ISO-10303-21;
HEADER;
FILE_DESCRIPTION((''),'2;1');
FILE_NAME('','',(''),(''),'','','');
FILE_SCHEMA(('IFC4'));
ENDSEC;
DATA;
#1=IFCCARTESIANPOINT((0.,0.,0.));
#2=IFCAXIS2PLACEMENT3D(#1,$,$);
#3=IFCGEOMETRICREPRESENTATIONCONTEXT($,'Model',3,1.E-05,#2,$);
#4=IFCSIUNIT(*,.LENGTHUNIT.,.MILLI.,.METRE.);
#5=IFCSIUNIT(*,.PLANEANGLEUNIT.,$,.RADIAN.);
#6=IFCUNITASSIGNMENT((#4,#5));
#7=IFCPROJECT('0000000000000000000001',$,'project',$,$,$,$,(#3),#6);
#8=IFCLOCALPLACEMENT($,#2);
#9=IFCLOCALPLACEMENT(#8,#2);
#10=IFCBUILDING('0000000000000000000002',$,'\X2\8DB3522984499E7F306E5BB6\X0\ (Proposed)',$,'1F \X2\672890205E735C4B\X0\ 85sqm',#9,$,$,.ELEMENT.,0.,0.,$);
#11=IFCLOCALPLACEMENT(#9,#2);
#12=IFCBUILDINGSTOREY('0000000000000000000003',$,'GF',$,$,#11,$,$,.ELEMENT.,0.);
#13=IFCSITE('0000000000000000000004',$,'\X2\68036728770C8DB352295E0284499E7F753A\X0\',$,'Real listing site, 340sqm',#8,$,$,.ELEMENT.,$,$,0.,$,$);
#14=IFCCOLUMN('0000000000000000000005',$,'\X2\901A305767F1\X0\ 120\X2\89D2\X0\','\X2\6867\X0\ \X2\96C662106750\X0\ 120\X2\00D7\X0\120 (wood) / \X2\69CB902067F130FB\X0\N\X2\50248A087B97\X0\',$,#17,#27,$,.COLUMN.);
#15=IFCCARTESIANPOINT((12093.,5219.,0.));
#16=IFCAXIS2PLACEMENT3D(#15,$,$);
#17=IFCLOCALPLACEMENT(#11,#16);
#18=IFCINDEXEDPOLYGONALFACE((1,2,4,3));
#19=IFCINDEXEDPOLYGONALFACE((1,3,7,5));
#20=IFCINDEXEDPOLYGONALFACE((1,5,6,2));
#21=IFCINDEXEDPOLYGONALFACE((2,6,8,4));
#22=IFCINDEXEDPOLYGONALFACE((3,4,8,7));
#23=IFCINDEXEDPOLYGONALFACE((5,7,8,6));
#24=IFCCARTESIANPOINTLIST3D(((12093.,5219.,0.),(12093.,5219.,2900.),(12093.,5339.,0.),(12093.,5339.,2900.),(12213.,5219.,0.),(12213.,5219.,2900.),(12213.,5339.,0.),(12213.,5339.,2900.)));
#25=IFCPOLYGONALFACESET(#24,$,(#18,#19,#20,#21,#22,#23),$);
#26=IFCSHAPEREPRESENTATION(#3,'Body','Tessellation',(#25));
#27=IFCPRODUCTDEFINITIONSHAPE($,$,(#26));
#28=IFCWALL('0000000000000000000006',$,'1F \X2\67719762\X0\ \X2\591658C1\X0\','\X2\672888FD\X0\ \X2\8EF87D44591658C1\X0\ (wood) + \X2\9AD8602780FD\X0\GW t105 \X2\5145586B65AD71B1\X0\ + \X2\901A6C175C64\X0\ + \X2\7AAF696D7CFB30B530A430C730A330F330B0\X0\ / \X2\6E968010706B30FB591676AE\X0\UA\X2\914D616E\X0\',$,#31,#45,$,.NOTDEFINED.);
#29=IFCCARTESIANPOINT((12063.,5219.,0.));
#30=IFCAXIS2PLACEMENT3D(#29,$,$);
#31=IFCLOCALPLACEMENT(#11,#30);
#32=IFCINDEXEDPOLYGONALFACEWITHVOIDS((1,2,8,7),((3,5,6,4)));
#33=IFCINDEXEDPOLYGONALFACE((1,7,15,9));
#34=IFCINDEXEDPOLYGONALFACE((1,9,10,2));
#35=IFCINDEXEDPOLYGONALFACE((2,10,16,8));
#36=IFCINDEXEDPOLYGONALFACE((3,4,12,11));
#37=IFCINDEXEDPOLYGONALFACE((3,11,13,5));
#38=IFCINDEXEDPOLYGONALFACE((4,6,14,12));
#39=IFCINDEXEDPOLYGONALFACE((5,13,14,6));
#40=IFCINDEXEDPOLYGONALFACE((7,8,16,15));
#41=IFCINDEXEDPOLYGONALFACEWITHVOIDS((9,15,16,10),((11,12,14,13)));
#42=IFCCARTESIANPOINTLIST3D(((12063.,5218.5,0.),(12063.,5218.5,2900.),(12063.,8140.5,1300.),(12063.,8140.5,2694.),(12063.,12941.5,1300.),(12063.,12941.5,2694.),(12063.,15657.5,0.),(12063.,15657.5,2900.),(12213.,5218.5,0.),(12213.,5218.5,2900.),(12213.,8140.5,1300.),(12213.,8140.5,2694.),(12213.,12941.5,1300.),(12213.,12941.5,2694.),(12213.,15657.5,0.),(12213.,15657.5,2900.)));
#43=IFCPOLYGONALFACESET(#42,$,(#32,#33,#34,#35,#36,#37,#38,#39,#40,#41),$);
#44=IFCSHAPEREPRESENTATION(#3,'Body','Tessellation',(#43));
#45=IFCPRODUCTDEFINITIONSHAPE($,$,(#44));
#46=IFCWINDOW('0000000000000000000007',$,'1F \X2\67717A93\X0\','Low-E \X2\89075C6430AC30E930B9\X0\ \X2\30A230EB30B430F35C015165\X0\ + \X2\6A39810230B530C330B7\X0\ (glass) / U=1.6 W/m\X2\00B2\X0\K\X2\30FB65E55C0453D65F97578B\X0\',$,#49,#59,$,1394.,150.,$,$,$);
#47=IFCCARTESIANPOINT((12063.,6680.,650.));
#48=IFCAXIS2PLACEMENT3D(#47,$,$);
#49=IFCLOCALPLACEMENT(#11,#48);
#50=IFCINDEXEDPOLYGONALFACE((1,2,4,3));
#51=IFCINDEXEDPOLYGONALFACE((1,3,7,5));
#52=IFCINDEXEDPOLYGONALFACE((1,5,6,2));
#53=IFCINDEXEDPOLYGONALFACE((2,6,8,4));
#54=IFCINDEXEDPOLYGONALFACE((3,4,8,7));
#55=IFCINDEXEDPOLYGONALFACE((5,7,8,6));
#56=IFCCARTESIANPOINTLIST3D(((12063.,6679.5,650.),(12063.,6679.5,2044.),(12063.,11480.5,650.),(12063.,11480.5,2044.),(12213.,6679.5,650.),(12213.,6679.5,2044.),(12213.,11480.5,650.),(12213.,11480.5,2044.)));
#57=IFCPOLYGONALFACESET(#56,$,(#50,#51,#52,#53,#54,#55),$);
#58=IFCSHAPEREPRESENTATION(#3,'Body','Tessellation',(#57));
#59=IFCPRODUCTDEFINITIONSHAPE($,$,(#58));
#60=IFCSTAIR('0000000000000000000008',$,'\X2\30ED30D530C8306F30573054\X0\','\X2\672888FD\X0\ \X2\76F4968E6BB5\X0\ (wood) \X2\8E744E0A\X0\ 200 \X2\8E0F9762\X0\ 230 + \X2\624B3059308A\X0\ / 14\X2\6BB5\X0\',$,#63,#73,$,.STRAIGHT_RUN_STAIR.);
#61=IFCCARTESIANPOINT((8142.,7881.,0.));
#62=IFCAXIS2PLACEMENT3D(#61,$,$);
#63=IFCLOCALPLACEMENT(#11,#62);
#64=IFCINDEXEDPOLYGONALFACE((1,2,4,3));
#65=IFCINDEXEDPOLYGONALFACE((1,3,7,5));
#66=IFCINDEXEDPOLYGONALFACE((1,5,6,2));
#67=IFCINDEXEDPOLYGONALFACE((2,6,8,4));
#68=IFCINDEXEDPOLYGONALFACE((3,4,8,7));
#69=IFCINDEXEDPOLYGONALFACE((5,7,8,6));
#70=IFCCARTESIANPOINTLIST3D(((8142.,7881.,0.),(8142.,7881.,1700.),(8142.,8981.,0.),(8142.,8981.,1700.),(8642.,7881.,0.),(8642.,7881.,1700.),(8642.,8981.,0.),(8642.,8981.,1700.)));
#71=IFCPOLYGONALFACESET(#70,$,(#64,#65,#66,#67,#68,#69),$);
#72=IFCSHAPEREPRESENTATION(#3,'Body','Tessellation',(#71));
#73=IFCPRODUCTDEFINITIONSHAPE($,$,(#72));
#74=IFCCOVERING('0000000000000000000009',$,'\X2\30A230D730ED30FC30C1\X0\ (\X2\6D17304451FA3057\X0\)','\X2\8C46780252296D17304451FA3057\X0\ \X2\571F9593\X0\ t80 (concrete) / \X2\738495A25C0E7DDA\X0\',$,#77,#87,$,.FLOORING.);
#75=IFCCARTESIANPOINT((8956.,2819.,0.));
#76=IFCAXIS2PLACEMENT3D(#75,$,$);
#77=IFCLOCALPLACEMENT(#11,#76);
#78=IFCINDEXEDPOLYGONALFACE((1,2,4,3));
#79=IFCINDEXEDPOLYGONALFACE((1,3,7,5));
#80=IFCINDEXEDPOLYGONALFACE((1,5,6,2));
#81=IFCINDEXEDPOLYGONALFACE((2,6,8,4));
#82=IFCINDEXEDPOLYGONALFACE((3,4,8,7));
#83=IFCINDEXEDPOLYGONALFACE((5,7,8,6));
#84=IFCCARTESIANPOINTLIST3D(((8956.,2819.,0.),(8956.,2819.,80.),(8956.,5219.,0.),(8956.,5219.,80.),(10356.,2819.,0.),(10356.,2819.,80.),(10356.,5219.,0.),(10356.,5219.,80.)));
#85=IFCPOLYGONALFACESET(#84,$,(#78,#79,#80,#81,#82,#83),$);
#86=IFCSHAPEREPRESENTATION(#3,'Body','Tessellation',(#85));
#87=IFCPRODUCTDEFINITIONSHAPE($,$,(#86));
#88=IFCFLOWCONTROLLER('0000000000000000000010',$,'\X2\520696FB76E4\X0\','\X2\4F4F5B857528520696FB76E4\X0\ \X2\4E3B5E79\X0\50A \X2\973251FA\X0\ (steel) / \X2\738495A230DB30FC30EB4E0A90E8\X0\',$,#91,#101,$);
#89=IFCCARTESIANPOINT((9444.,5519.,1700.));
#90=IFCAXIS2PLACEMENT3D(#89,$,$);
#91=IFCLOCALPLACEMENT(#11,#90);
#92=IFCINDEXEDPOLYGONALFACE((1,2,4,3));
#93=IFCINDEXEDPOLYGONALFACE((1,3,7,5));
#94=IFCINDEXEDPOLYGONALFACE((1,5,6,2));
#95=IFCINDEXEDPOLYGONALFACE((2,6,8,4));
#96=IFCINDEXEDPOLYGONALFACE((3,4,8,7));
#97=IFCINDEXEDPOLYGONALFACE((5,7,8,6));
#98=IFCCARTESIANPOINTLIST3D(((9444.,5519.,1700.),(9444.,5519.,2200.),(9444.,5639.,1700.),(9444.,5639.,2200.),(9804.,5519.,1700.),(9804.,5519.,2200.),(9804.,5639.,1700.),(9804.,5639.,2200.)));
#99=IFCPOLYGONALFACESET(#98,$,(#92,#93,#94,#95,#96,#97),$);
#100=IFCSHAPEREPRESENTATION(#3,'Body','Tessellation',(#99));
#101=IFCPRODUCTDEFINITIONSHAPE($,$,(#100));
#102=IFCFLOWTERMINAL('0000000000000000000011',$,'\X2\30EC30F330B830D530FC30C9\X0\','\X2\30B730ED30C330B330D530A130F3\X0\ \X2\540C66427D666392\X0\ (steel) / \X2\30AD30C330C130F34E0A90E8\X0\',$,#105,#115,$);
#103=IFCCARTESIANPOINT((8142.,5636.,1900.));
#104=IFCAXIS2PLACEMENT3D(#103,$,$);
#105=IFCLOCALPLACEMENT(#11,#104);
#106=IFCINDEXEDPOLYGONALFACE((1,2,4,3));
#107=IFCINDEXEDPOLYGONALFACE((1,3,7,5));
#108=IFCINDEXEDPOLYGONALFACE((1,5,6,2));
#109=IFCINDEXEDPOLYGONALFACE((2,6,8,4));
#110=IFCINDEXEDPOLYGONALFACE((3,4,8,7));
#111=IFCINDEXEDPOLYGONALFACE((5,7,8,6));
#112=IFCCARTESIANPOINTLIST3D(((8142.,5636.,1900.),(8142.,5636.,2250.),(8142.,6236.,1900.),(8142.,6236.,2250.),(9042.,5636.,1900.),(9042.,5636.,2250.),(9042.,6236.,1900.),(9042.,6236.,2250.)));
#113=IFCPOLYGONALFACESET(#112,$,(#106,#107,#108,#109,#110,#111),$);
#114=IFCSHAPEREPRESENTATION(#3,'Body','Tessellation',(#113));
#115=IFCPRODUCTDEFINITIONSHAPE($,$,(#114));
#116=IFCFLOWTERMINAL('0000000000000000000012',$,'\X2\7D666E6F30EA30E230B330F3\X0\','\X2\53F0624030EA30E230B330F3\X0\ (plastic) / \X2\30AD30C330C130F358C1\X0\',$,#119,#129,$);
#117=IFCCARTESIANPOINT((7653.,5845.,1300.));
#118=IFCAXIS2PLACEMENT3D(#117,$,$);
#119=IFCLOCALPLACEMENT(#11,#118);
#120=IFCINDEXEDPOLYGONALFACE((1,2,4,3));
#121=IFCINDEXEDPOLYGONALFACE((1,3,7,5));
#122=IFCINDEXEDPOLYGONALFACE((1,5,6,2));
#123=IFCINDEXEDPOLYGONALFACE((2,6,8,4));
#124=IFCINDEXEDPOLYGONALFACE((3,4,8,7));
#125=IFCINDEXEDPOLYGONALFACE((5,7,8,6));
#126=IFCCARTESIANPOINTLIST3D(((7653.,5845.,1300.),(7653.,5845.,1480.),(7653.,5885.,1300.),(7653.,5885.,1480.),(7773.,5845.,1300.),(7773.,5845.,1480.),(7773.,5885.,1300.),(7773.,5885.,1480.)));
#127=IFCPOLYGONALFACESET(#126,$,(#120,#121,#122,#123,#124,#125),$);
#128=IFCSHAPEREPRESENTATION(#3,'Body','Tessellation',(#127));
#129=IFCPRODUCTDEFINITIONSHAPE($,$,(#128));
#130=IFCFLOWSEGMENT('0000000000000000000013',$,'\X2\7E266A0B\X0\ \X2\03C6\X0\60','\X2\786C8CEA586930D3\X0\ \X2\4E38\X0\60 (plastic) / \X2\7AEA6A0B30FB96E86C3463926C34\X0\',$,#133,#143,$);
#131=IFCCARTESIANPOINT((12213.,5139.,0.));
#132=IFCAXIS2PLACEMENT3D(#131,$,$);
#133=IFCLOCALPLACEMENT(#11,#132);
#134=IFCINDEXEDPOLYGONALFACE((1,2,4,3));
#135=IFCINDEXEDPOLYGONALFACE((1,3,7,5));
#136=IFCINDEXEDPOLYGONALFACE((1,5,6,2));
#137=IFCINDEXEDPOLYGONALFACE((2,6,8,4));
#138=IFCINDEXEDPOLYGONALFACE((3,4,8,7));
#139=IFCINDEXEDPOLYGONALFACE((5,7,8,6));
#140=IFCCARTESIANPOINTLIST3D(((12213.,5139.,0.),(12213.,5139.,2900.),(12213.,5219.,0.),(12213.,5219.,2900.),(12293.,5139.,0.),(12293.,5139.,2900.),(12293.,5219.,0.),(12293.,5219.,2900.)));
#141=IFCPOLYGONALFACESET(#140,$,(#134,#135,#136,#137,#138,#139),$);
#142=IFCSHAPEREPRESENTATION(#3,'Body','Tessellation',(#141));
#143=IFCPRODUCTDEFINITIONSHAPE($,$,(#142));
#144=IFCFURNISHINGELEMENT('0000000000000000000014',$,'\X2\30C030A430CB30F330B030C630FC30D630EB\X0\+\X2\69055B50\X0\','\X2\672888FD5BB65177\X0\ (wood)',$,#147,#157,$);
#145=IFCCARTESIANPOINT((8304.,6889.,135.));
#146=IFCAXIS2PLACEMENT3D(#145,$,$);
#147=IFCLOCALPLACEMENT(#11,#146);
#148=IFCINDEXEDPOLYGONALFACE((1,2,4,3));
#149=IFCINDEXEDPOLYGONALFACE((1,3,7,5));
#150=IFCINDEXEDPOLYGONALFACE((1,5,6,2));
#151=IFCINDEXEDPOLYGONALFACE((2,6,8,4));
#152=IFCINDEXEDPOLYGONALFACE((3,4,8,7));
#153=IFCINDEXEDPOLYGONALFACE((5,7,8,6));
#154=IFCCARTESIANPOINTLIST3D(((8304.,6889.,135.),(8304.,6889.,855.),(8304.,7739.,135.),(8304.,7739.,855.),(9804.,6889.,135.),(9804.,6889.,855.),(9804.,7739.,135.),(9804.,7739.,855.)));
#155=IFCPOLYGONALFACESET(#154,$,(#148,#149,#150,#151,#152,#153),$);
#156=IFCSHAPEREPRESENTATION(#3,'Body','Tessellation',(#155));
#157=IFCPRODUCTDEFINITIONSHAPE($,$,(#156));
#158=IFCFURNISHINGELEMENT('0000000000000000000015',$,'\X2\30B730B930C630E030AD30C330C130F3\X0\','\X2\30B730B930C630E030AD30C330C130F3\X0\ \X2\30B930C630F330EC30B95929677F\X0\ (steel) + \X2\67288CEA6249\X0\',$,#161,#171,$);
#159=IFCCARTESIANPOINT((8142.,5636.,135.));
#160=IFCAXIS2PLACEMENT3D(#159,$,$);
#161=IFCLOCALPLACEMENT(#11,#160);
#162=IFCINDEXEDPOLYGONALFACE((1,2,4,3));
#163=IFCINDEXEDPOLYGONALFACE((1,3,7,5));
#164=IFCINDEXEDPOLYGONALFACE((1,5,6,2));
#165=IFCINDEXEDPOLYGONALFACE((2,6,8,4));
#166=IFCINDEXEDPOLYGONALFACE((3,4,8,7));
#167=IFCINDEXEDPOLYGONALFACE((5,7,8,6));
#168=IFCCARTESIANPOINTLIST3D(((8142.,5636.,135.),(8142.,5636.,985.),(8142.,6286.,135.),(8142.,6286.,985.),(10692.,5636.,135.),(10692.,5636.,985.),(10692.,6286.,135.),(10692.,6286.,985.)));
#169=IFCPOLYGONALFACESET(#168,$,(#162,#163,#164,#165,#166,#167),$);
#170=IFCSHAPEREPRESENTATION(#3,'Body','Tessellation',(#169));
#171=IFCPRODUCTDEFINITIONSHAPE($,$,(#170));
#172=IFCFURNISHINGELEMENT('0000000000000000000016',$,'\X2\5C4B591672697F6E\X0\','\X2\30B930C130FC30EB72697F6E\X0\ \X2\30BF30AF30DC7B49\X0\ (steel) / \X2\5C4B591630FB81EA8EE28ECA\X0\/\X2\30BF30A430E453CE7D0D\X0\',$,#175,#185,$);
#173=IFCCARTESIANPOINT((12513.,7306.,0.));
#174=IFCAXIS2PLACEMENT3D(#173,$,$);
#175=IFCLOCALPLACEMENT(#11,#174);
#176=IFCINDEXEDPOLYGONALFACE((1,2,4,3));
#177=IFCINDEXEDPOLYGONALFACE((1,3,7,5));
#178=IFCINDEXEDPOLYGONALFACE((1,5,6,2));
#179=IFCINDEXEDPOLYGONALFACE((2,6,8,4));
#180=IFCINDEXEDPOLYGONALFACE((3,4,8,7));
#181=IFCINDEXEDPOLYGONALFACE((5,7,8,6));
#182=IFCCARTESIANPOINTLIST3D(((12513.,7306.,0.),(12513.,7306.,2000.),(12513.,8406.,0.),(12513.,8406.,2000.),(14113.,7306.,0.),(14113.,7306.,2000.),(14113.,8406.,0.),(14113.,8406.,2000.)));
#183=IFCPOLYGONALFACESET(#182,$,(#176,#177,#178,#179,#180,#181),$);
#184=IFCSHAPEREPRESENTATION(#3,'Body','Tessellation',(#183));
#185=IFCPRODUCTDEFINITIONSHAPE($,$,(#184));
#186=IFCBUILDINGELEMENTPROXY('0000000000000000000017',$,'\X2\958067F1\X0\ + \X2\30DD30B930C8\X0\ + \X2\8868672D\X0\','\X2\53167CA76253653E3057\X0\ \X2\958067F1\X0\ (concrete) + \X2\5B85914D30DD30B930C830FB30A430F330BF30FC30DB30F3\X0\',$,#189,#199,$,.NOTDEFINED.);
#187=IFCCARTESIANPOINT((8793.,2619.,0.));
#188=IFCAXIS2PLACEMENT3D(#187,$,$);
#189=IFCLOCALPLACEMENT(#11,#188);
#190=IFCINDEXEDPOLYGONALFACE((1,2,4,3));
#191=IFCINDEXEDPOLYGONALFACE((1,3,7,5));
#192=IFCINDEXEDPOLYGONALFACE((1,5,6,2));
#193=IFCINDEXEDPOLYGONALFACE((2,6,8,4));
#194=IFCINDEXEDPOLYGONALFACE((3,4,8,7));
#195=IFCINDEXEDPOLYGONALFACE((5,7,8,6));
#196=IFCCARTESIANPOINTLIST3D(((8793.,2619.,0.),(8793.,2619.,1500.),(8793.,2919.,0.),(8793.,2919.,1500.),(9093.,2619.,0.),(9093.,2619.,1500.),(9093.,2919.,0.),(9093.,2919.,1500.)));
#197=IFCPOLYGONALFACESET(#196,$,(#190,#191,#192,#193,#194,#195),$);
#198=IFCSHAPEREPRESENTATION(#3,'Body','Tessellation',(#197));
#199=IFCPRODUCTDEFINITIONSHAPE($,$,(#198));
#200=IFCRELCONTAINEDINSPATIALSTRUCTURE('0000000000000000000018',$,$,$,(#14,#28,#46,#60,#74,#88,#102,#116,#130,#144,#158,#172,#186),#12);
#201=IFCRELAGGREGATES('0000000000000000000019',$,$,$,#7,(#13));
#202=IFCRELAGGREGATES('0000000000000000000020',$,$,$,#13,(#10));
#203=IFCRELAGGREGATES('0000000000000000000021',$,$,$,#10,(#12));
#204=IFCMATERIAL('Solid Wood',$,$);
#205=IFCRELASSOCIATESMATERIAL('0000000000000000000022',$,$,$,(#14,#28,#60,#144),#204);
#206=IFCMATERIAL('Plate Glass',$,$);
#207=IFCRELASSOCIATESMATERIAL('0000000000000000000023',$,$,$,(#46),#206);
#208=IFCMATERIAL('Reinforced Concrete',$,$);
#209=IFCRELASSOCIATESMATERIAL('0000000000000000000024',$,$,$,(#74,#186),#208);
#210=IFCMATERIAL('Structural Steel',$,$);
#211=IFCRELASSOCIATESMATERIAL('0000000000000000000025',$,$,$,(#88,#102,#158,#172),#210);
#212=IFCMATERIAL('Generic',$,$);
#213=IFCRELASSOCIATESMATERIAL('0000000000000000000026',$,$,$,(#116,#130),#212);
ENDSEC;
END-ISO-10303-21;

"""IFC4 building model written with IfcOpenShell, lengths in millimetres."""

from ifc_helpers import new_model, si_unit, frame, frame_2d, origin, place, context, project, spatial, rectangle, extrude, material, element, fill, save


model = new_model("IFC4")

# Units and contexts
model_context = context("Model", 3, precision=1e-05, world=origin())
ifc_project = project(units=[si_unit("LENGTHUNIT", "METRE", prefix="MILLI"), si_unit("PLANEANGLEUNIT", "RADIAN")], contexts=[model_context])

# Site, building, storey
site_placement = place(None, origin())
site = spatial("IfcSite", under=ifc_project, at=site_placement, Name="栃木県足利市葉鹿町", ObjectType="Real listing site, 340sqm", CompositionType="ELEMENT", RefElevation=0.0)
building_placement = place(site_placement, origin())
building = spatial("IfcBuilding", under=site, at=building_placement, Name="足利葉鹿の家 (Proposed)", ObjectType="1F 木造平屋 85sqm", CompositionType="ELEMENT", ElevationOfRefHeight=0.0, ElevationOfTerrain=0.0)
storey_placement = place(building_placement, origin())
storey = spatial("IfcBuildingStorey", under=building, at=storey_placement, Name="GF", CompositionType="ELEMENT", Elevation=0.0)

# Column
ifc_material_1 = material(Name="Solid Wood")
column_1_placement = place(storey_placement, frame((12093.0, 5219.0, 0.0)))
element("IfcColumn", 1, at=column_1_placement, inside=storey, material=ifc_material_1, Name="通し柱 120角", Description="桧 集成材 120×120 (wood) / 構造柱・N値計算", PredefinedType="COLUMN", context=model_context, shape_type="SweptSolid", body=[
    extrude(rectangle(XDim=120.0, YDim=120.0, at=frame_2d((60.0, 60.0))), frame((12093.0, 5219.0, 0.0)), (0.0, 0.0, 1.0), 2900.0),
])

# Wall, opening, window
wall_1_placement = place(storey_placement, frame((12063.0, 5219.0, 0.0)))
wall_1 = element("IfcWall", 2, at=wall_1_placement, inside=storey, material=ifc_material_1, Name="1F 東面 外壁", Description="木製 軸組外壁 (wood) + 高性能GW t105 充填断熱 + 通気層 + 窯業系サイディング / 準耐火・外皮UA配慮", PredefinedType="NOTDEFINED", context=model_context, shape_type="SweptSolid", body=[
    extrude(rectangle(XDim=150.0, YDim=10439.0, at=frame_2d((75.0, 5219.0))), frame((12063.0, 5219.0, 0.0)), (0.0, 0.0, 1.0), 2900.0),
])
opening_placement = place(storey_placement, frame((12063.0, 6680.0, 650.0)))
opening = element("IfcOpeningElement", 3, at=opening_placement, cuts=wall_1, PredefinedType="NOTDEFINED", context=model_context, shape_type="SweptSolid", body=[
    extrude(rectangle(XDim=150.0, YDim=4801.0, at=frame_2d((75.0, 2400.0))), frame((12063.0, 6680.0, 650.0)), (0.0, 0.0, 1.0), 1394.0),
])
ifc_material_2 = material(Name="Plate Glass")
window_placement = place(storey_placement, frame((12063.0, 6680.0, 650.0)))
window = element("IfcWindow", 4, at=window_placement, inside=storey, material=ifc_material_2, Name="1F 東窓", Description="Low-E 複層ガラス アルゴン封入 + 樹脂サッシ (glass) / U=1.6 W/m²K・日射取得型", OverallHeight=1394.0, OverallWidth=150.0, context=model_context, shape_type="SweptSolid", body=[
    extrude(rectangle(XDim=150.0, YDim=4801.0, at=frame_2d((75.0, 2400.0))), frame((12063.0, 6680.0, 650.0)), (0.0, 0.0, 1.0), 1394.0),
])
fill(opening, window)

# Stair
stair_placement = place(storey_placement, frame((8142.0, 7881.0, 0.0)))
element("IfcStair", 5, at=stair_placement, inside=storey, material=ifc_material_1, Name="ロフトはしご", Description="木製 直階段 (wood) 蹴上 200 踏面 230 + 手すり / 14段", PredefinedType="STRAIGHT_RUN_STAIR", context=model_context, shape_type="SweptSolid", body=[
    extrude(rectangle(XDim=500.0, YDim=1100.0, at=frame_2d((250.0, 550.0))), frame((8142.0, 7881.0, 0.0)), (0.0, 0.0, 1.0), 1700.0),
])

# Covering
ifc_material_3 = material(Name="Reinforced Concrete")
covering_placement = place(storey_placement, frame((8956.0, 2819.0, 0.0)))
element("IfcCovering", 6, at=covering_placement, inside=storey, material=ifc_material_3, Name="アプローチ (洗い出し)", Description="豆砂利洗い出し 土間 t80 (concrete) / 玄関導線", PredefinedType="FLOORING", context=model_context, shape_type="SweptSolid", body=[
    extrude(rectangle(XDim=1400.0, YDim=2400.0, at=frame_2d((700.0, 1200.0))), frame((8956.0, 2819.0, 0.0)), (0.0, 0.0, 1.0), 80.0),
])

# Flow controller
ifc_material_4 = material(Name="Structural Steel")
flow_controller_placement = place(storey_placement, frame((9444.0, 5519.0, 1700.0)))
element("IfcFlowController", 7, at=flow_controller_placement, inside=storey, material=ifc_material_4, Name="分電盤", Description="住宅用分電盤 主幹50A 露出 (steel) / 玄関ホール上部", context=model_context, shape_type="SweptSolid", body=[
    extrude(rectangle(XDim=360.0, YDim=120.0, at=frame_2d((180.0, 60.0))), frame((9444.0, 5519.0, 1700.0)), (0.0, 0.0, 1.0), 500.0),
])

# Flow terminals
flow_terminal_1_placement = place(storey_placement, frame((8142.0, 5636.0, 1900.0)))
element("IfcFlowTerminal", 8, at=flow_terminal_1_placement, inside=storey, material=ifc_material_4, Name="レンジフード", Description="シロッコファン 同時給排 (steel) / キッチン上部", context=model_context, shape_type="SweptSolid", body=[
    extrude(rectangle(XDim=900.0, YDim=600.0, at=frame_2d((450.0, 300.0))), frame((8142.0, 5636.0, 1900.0)), (0.0, 0.0, 1.0), 350.0),
])
ifc_material_5 = material(Name="Generic")
flow_terminal_2_placement = place(storey_placement, frame((7653.0, 5845.0, 1300.0)))
element("IfcFlowTerminal", 9, at=flow_terminal_2_placement, inside=storey, material=ifc_material_5, Name="給湯リモコン", Description="台所リモコン (plastic) / キッチン壁", context=model_context, shape_type="SweptSolid", body=[
    extrude(rectangle(XDim=120.0, YDim=40.0, at=frame_2d((60.0, 20.0))), frame((7653.0, 5845.0, 1300.0)), (0.0, 0.0, 1.0), 180.0),
])

# Flow segment
flow_segment_placement = place(storey_placement, frame((12213.0, 5139.0, 0.0)))
element("IfcFlowSegment", 10, at=flow_segment_placement, inside=storey, material=ifc_material_5, Name="縦樋 φ60", Description="硬質塩ビ 丸60 (plastic) / 竪樋・雨水排水", context=model_context, shape_type="SweptSolid", body=[
    extrude(rectangle(XDim=80.0, YDim=80.0, at=frame_2d((40.0, 40.0))), frame((12213.0, 5139.0, 0.0)), (0.0, 0.0, 1.0), 2900.0),
])

# Furnishing elements
furnishing_1_placement = place(storey_placement, frame((8304.0, 6889.0, 135.0)))
element("IfcFurnishingElement", 11, at=furnishing_1_placement, inside=storey, material=ifc_material_1, Name="ダイニングテーブル+椅子", Description="木製家具 (wood)", context=model_context, shape_type="SweptSolid", body=[
    extrude(rectangle(XDim=1500.0, YDim=850.0, at=frame_2d((750.0, 425.0))), frame((8304.0, 6889.0, 135.0)), (0.0, 0.0, 1.0), 720.0),
])
furnishing_2_placement = place(storey_placement, frame((8142.0, 5636.0, 135.0)))
element("IfcFurnishingElement", 12, at=furnishing_2_placement, inside=storey, material=ifc_material_4, Name="システムキッチン", Description="システムキッチン ステンレス天板 (steel) + 木質扉", context=model_context, shape_type="SweptSolid", body=[
    extrude(rectangle(XDim=2550.0, YDim=650.0, at=frame_2d((1275.0, 325.0))), frame((8142.0, 5636.0, 135.0)), (0.0, 0.0, 1.0), 850.0),
])
furnishing_3_placement = place(storey_placement, frame((12513.0, 7306.0, 0.0)))
element("IfcFurnishingElement", 13, at=furnishing_3_placement, inside=storey, material=ifc_material_4, Name="屋外物置", Description="スチール物置 タクボ等 (steel) / 屋外・自転車/タイヤ収納", context=model_context, shape_type="SweptSolid", body=[
    extrude(rectangle(XDim=1600.0, YDim=1100.0, at=frame_2d((800.0, 550.0))), frame((12513.0, 7306.0, 0.0)), (0.0, 0.0, 1.0), 2000.0),
])

# Building element proxy
proxy_placement = place(storey_placement, frame((8793.0, 2619.0, 0.0)))
element("IfcBuildingElementProxy", 14, at=proxy_placement, inside=storey, material=ifc_material_3, Name="門柱 + ポスト + 表札", Description="化粧打放し 門柱 (concrete) + 宅配ポスト・インターホン", PredefinedType="NOTDEFINED", context=model_context, shape_type="SweptSolid", body=[
    extrude(rectangle(XDim=300.0, YDim=300.0, at=frame_2d((150.0, 150.0))), frame((8793.0, 2619.0, 0.0)), (0.0, 0.0, 1.0), 1500.0),
])

save(model, "model.ifc")
